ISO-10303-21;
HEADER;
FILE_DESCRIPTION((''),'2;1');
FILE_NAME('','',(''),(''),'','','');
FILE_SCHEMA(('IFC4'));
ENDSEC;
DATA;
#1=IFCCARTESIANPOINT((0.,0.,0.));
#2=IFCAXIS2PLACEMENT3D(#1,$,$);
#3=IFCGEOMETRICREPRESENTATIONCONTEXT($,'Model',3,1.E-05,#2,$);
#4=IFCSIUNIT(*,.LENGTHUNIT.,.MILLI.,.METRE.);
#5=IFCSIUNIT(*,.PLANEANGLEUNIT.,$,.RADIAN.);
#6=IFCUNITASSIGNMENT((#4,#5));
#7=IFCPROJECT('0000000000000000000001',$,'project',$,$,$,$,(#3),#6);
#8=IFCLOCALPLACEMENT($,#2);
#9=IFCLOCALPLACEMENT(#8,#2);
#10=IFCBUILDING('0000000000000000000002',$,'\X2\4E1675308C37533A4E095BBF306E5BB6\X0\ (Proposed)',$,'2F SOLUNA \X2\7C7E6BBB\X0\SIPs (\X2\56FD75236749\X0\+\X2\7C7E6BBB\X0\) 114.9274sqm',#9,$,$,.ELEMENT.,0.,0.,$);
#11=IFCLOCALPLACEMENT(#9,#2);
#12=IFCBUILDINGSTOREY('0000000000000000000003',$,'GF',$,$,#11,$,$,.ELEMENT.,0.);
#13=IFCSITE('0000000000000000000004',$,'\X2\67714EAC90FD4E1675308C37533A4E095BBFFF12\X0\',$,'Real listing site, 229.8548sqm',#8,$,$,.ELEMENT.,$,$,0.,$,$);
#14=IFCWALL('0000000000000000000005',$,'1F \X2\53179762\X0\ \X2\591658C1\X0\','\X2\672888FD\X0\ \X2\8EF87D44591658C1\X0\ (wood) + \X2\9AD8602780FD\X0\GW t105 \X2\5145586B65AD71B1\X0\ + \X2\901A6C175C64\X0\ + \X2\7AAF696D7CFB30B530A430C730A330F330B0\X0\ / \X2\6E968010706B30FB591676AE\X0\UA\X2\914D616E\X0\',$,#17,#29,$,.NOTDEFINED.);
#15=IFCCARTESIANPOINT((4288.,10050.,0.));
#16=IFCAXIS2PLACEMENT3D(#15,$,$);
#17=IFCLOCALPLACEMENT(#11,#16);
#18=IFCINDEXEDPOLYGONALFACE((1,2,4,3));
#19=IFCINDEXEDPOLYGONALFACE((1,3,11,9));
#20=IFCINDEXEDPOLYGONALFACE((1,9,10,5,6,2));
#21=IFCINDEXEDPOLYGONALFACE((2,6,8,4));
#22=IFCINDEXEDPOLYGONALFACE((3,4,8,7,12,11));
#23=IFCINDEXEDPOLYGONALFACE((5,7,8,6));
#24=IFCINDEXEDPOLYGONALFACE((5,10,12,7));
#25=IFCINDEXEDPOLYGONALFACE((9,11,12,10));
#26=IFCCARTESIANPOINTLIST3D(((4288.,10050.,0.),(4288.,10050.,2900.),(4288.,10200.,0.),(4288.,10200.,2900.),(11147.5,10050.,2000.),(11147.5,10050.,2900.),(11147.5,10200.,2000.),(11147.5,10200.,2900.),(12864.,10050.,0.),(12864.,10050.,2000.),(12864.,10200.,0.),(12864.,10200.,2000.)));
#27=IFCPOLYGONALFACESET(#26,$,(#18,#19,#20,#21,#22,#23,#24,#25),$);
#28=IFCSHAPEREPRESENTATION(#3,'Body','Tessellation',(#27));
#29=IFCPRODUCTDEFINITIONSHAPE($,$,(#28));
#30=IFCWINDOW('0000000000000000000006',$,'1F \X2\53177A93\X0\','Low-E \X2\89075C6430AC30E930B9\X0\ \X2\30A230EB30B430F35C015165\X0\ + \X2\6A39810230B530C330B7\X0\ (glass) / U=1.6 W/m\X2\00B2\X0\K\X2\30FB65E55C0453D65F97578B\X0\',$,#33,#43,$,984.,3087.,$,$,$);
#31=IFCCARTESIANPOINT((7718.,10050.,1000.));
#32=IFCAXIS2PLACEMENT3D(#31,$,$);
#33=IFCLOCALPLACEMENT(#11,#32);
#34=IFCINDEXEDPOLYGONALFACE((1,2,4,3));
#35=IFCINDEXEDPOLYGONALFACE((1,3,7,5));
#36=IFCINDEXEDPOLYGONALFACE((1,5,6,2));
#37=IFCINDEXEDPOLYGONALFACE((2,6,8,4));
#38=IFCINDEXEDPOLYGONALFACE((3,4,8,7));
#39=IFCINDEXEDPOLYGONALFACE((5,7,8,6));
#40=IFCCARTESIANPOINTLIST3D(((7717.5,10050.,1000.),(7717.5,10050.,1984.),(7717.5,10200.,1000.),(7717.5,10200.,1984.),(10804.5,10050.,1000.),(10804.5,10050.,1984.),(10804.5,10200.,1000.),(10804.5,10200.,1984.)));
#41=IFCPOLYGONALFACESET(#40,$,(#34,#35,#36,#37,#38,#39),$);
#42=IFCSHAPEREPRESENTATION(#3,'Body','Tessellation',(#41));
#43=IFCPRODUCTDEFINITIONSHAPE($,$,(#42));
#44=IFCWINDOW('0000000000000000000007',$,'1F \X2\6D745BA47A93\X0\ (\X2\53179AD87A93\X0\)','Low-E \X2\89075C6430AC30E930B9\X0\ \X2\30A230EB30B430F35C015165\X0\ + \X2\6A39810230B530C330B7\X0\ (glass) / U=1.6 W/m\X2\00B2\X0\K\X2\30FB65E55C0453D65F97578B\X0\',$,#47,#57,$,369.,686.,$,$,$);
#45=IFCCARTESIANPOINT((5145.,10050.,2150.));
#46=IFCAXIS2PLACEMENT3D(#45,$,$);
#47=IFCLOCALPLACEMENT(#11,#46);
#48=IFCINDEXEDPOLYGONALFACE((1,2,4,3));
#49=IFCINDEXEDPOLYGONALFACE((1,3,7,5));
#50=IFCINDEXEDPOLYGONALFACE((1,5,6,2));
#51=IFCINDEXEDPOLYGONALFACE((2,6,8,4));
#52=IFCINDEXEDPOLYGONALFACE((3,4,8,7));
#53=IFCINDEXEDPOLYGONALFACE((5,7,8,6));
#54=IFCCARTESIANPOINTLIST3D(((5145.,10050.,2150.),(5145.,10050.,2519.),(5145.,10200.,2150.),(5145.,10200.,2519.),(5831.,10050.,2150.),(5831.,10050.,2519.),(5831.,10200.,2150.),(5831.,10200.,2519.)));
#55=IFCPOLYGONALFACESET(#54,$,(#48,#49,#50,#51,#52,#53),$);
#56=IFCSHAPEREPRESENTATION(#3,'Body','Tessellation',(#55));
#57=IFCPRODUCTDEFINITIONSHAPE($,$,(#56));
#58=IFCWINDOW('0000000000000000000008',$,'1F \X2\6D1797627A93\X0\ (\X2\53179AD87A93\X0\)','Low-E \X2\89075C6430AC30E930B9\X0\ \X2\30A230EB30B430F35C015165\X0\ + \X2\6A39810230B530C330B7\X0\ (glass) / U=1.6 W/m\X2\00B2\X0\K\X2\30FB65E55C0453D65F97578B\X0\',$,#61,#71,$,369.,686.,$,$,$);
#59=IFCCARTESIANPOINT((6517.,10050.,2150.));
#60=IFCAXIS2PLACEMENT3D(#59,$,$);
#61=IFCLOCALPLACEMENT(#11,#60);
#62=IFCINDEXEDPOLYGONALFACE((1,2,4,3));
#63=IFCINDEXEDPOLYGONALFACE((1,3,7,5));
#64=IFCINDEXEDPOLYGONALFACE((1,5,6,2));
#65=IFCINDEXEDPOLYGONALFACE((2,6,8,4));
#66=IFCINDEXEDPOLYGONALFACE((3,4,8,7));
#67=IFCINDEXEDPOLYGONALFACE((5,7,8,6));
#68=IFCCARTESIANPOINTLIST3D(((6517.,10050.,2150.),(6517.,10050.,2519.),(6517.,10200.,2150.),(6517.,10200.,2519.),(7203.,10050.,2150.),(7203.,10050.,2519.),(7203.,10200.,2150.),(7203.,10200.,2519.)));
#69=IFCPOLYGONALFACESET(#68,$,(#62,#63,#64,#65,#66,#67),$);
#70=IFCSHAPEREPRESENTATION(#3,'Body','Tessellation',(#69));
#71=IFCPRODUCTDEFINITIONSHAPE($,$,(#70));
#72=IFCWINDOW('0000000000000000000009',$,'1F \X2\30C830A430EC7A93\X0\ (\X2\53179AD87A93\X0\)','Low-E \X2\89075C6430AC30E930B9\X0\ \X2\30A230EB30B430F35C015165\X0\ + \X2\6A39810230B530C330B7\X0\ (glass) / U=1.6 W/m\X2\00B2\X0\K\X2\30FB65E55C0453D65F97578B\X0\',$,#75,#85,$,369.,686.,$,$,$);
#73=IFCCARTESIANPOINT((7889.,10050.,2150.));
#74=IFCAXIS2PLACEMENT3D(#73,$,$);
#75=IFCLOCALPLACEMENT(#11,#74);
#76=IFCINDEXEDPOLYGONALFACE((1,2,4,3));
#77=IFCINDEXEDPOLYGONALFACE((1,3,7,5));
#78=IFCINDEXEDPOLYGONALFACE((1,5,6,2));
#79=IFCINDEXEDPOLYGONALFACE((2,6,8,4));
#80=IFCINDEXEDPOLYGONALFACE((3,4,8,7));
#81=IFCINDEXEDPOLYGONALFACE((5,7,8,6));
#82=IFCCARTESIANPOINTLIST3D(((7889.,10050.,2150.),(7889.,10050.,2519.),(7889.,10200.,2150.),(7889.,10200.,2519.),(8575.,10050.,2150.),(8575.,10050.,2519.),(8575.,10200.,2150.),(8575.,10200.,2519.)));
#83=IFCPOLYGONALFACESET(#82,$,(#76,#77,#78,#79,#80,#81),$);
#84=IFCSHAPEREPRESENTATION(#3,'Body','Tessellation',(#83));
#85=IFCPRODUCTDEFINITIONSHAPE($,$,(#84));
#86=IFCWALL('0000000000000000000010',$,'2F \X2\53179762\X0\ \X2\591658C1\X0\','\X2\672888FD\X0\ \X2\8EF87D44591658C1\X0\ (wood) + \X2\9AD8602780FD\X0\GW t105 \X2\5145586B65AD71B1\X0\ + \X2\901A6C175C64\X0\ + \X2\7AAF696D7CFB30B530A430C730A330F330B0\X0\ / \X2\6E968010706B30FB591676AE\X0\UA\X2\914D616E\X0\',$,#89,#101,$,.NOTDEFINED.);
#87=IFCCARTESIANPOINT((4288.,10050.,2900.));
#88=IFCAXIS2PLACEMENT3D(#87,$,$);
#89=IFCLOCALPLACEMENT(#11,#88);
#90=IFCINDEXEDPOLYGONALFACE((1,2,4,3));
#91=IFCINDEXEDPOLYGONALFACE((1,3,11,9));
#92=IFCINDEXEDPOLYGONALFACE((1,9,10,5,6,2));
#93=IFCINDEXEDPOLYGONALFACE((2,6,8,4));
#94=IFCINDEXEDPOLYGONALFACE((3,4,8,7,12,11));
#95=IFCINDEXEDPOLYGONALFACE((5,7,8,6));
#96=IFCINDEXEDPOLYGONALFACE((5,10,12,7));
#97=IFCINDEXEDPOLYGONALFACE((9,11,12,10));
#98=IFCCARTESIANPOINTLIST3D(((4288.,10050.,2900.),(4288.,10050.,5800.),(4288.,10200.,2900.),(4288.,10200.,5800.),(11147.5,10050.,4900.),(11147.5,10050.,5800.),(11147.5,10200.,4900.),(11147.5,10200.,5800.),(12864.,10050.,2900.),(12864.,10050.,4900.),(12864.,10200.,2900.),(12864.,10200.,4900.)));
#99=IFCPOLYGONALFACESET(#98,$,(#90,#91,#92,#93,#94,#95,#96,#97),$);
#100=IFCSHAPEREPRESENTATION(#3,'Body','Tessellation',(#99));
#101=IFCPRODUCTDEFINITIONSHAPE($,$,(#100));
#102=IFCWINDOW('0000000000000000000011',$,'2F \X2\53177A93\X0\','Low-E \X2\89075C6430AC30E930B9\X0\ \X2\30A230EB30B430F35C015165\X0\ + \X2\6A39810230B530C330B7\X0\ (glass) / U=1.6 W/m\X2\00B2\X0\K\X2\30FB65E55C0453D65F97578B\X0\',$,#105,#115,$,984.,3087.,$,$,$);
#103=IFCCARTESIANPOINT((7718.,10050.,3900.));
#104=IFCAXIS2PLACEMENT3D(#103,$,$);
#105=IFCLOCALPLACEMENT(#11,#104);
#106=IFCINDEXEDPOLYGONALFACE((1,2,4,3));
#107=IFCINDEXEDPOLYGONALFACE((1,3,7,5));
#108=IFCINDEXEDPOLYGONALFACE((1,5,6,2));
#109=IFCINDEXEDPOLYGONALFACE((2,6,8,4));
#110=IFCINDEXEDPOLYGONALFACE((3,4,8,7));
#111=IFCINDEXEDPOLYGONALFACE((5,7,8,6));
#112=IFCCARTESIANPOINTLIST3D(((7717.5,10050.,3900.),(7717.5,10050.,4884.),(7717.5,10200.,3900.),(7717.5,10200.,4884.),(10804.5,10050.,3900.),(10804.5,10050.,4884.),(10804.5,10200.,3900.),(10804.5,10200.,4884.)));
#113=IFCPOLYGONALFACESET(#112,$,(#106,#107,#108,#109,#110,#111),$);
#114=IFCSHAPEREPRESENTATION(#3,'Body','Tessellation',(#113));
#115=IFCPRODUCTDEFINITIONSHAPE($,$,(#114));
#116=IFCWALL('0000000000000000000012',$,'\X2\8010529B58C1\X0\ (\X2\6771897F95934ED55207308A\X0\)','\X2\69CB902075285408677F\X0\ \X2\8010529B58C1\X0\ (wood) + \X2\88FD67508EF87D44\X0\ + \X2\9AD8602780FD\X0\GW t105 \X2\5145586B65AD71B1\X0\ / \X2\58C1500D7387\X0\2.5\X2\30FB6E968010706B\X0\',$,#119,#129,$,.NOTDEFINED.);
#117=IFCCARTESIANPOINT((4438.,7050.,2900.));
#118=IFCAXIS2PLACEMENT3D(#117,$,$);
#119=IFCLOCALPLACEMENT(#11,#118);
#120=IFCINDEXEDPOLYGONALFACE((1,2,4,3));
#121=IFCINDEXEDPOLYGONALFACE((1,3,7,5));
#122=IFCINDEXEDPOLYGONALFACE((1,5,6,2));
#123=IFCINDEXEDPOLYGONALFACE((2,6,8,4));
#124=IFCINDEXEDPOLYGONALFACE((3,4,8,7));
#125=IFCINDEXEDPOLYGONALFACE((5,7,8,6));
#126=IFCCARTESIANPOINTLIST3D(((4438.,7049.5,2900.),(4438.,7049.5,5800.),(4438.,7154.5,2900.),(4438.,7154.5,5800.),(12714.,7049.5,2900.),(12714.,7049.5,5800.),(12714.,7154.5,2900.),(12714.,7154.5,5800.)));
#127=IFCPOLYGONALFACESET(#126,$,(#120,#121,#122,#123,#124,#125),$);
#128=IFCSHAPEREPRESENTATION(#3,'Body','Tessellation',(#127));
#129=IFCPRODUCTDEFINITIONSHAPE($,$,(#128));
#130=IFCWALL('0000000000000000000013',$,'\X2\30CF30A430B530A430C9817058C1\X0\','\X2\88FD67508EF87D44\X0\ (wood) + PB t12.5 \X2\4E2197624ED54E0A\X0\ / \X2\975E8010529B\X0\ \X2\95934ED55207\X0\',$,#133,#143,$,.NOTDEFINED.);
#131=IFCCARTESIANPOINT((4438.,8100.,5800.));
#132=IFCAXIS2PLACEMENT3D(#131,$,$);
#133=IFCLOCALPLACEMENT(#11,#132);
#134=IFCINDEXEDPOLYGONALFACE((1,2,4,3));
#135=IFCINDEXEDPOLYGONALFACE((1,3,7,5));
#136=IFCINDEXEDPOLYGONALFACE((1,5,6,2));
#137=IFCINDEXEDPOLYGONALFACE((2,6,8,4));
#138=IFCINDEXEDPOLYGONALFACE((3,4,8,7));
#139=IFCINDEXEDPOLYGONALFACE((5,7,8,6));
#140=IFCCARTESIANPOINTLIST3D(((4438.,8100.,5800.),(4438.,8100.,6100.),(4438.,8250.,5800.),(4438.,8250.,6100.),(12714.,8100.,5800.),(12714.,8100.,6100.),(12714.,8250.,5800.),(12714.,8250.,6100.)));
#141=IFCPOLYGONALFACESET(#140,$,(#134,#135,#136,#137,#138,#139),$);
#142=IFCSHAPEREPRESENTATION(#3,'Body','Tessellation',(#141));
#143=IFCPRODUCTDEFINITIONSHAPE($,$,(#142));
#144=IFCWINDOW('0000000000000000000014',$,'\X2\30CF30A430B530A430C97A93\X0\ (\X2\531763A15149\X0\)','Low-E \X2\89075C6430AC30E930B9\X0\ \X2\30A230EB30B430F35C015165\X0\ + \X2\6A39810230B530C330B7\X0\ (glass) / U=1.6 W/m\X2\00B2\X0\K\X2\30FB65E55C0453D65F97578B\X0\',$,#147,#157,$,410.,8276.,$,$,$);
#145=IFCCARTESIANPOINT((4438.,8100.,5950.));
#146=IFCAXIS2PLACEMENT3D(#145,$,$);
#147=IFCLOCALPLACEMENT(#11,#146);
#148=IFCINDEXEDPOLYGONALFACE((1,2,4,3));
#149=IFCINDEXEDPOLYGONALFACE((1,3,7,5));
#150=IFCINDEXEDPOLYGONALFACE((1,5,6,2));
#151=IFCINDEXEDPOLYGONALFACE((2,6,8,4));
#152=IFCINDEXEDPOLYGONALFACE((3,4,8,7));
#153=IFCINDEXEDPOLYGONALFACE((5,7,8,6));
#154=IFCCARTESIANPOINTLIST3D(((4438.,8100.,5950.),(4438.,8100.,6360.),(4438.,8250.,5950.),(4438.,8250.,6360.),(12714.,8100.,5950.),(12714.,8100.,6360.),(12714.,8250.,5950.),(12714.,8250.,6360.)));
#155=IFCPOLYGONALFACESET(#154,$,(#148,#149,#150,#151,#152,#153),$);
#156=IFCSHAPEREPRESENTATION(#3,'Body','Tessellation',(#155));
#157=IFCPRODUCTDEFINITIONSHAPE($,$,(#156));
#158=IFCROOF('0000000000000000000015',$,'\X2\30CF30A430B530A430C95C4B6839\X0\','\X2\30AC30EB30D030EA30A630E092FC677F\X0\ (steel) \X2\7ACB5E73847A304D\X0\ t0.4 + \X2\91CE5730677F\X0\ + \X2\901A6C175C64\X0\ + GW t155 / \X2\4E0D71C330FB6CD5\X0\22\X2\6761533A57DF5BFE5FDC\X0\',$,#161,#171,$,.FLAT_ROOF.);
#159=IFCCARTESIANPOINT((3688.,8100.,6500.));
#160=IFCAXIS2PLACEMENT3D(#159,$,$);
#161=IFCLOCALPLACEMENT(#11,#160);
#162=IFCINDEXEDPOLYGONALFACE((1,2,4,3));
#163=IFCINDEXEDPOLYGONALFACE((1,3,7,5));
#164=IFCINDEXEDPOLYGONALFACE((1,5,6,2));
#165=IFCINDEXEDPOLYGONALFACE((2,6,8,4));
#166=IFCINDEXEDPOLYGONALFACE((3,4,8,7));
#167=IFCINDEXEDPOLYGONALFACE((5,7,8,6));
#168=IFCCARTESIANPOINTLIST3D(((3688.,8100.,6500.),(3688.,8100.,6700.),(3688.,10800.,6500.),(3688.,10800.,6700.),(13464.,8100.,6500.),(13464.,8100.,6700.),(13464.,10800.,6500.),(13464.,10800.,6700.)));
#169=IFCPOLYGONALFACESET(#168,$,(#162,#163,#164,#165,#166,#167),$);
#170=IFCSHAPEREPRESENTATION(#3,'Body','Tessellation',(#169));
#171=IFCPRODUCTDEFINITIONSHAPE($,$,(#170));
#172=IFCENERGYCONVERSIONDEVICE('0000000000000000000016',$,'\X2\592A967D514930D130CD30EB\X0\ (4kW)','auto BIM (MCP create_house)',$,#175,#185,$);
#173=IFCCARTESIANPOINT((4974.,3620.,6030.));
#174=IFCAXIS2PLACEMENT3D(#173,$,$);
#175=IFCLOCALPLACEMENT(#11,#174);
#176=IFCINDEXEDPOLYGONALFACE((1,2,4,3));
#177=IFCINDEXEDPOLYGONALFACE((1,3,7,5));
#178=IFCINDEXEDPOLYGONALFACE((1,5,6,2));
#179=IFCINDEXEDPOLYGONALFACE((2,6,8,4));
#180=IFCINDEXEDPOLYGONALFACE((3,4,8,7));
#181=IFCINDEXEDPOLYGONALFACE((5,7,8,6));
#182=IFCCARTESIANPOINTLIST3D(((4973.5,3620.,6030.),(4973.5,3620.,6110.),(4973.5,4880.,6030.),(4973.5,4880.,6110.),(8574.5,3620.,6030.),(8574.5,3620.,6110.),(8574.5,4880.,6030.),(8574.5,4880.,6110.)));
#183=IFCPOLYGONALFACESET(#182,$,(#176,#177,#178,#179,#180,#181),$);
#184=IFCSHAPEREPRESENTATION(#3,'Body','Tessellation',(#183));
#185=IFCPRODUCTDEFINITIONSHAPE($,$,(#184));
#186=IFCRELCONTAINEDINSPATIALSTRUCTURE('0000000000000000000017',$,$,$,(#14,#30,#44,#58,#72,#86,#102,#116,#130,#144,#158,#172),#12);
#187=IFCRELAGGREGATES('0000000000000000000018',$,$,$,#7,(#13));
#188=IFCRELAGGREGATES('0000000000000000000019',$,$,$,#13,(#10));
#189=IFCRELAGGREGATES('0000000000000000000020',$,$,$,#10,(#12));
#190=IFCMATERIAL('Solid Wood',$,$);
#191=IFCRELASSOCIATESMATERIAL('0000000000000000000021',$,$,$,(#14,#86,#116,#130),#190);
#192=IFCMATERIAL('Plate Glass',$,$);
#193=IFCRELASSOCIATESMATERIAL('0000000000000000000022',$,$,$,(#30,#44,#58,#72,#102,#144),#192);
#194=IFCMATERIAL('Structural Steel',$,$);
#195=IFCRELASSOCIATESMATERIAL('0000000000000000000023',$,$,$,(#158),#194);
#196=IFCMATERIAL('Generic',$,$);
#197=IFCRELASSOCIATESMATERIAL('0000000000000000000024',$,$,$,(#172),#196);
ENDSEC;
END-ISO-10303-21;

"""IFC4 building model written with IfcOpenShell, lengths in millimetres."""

from ifc_helpers import new_model, si_unit, frame, frame_2d, origin, place, context, project, spatial, rectangle, extrude, material, element, fill, save


model = new_model("IFC4")

# Units and contexts
model_context = context("Model", 3, precision=1e-05, world=origin())
ifc_project = project(units=[si_unit("LENGTHUNIT", "METRE", prefix="MILLI"), si_unit("PLANEANGLEUNIT", "RADIAN")], contexts=[model_context])

# Site, building, storey
site_placement = place(None, origin())
site = spatial("IfcSite", under=ifc_project, at=site_placement, Name="東京都世田谷区三宿２", ObjectType="Real listing site, 229.8548sqm", CompositionType="ELEMENT", RefElevation=0.0)
building_placement = place(site_placement, origin())
building = spatial("IfcBuilding", under=site, at=building_placement, Name="世田谷区三宿の家 (Proposed)", ObjectType="2F SOLUNA 籾殻SIPs (国産杉+籾殻) 114.9274sqm", CompositionType="ELEMENT", ElevationOfRefHeight=0.0, ElevationOfTerrain=0.0)
storey_placement = place(building_placement, origin())
storey = spatial("IfcBuildingStorey", under=building, at=storey_placement, Name="GF", CompositionType="ELEMENT", Elevation=0.0)

# Wall, openings, windows
ifc_material_1 = material(Name="Solid Wood")
wall_1_placement = place(storey_placement, frame((4288.0, 10050.0, 0.0)))
wall_1 = element("IfcWall", 1, at=wall_1_placement, inside=storey, material=ifc_material_1, Name="1F 北面 外壁", Description="木製 軸組外壁 (wood) + 高性能GW t105 充填断熱 + 通気層 + 窯業系サイディング / 準耐火・外皮UA配慮", PredefinedType="NOTDEFINED", context=model_context, shape_type="SweptSolid", body=[
    extrude(rectangle(XDim=8576.0, YDim=150.0, at=frame_2d((4288.0, 75.0))), frame((4288.0, 10050.0, 0.0)), (0.0, 0.0, 1.0), 2900.0),
])
opening_1_placement = place(storey_placement, frame((7718.0, 10050.0, 1000.0)))
opening_1 = element("IfcOpeningElement", 2, at=opening_1_placement, cuts=wall_1, PredefinedType="NOTDEFINED", context=model_context, shape_type="SweptSolid", body=[
    extrude(rectangle(XDim=3087.0, YDim=150.0, at=frame_2d((1543.0, 75.0))), frame((7718.0, 10050.0, 1000.0)), (0.0, 0.0, 1.0), 984.0),
])
opening_2_placement = place(storey_placement, frame((5145.0, 10050.0, 2150.0)))
opening_2 = element("IfcOpeningElement", 3, at=opening_2_placement, cuts=wall_1, PredefinedType="NOTDEFINED", context=model_context, shape_type="SweptSolid", body=[
    extrude(rectangle(XDim=686.0, YDim=150.0, at=frame_2d((343.0, 75.0))), frame((5145.0, 10050.0, 2150.0)), (0.0, 0.0, 1.0), 369.0),
])
opening_3_placement = place(storey_placement, frame((6517.0, 10050.0, 2150.0)))
opening_3 = element("IfcOpeningElement", 4, at=opening_3_placement, cuts=wall_1, PredefinedType="NOTDEFINED", context=model_context, shape_type="SweptSolid", body=[
    extrude(rectangle(XDim=686.0, YDim=150.0, at=frame_2d((343.0, 75.0))), frame((6517.0, 10050.0, 2150.0)), (0.0, 0.0, 1.0), 369.0),
])
opening_4_placement = place(storey_placement, frame((7889.0, 10050.0, 2150.0)))
opening_4 = element("IfcOpeningElement", 5, at=opening_4_placement, cuts=wall_1, PredefinedType="NOTDEFINED", context=model_context, shape_type="SweptSolid", body=[
    extrude(rectangle(XDim=686.0, YDim=150.0, at=frame_2d((343.0, 75.0))), frame((7889.0, 10050.0, 2150.0)), (0.0, 0.0, 1.0), 369.0),
])
ifc_material_2 = material(Name="Plate Glass")
window_1_placement = place(storey_placement, frame((7718.0, 10050.0, 1000.0)))
window_1 = element("IfcWindow", 6, at=window_1_placement, inside=storey, material=ifc_material_2, Name="1F 北窓", Description="Low-E 複層ガラス アルゴン封入 + 樹脂サッシ (glass) / U=1.6 W/m²K・日射取得型", OverallHeight=984.0, OverallWidth=3087.0, context=model_context, shape_type="SweptSolid", body=[
    extrude(rectangle(XDim=3087.0, YDim=150.0, at=frame_2d((1543.0, 75.0))), frame((7718.0, 10050.0, 1000.0)), (0.0, 0.0, 1.0), 984.0),
])
fill(opening_1, window_1)
window_2_placement = place(storey_placement, frame((5145.0, 10050.0, 2150.0)))
window_2 = element("IfcWindow", 7, at=window_2_placement, inside=storey, material=ifc_material_2, Name="1F 浴室窓 (北高窓)", Description="Low-E 複層ガラス アルゴン封入 + 樹脂サッシ (glass) / U=1.6 W/m²K・日射取得型", OverallHeight=369.0, OverallWidth=686.0, context=model_context, shape_type="SweptSolid", body=[
    extrude(rectangle(XDim=686.0, YDim=150.0, at=frame_2d((343.0, 75.0))), frame((5145.0, 10050.0, 2150.0)), (0.0, 0.0, 1.0), 369.0),
])
fill(opening_2, window_2)
window_3_placement = place(storey_placement, frame((6517.0, 10050.0, 2150.0)))
window_3 = element("IfcWindow", 8, at=window_3_placement, inside=storey, material=ifc_material_2, Name="1F 洗面窓 (北高窓)", Description="Low-E 複層ガラス アルゴン封入 + 樹脂サッシ (glass) / U=1.6 W/m²K・日射取得型", OverallHeight=369.0, OverallWidth=686.0, context=model_context, shape_type="SweptSolid", body=[
    extrude(rectangle(XDim=686.0, YDim=150.0, at=frame_2d((343.0, 75.0))), frame((6517.0, 10050.0, 2150.0)), (0.0, 0.0, 1.0), 369.0),
])
fill(opening_3, window_3)
window_4_placement = place(storey_placement, frame((7889.0, 10050.0, 2150.0)))
window_4 = element("IfcWindow", 9, at=window_4_placement, inside=storey, material=ifc_material_2, Name="1F トイレ窓 (北高窓)", Description="Low-E 複層ガラス アルゴン封入 + 樹脂サッシ (glass) / U=1.6 W/m²K・日射取得型", OverallHeight=369.0, OverallWidth=686.0, context=model_context, shape_type="SweptSolid", body=[
    extrude(rectangle(XDim=686.0, YDim=150.0, at=frame_2d((343.0, 75.0))), frame((7889.0, 10050.0, 2150.0)), (0.0, 0.0, 1.0), 369.0),
])
fill(opening_4, window_4)

# Wall, opening, window
wall_2_placement = place(storey_placement, frame((4288.0, 10050.0, 2900.0)))
wall_2 = element("IfcWall", 10, at=wall_2_placement, inside=storey, material=ifc_material_1, Name="2F 北面 外壁", Description="木製 軸組外壁 (wood) + 高性能GW t105 充填断熱 + 通気層 + 窯業系サイディング / 準耐火・外皮UA配慮", PredefinedType="NOTDEFINED", context=model_context, shape_type="SweptSolid", body=[
    extrude(rectangle(XDim=8576.0, YDim=150.0, at=frame_2d((4288.0, 75.0))), frame((4288.0, 10050.0, 2900.0)), (0.0, 0.0, 1.0), 2900.0),
])
opening_5_placement = place(storey_placement, frame((7718.0, 10050.0, 3900.0)))
opening_5 = element("IfcOpeningElement", 11, at=opening_5_placement, cuts=wall_2, PredefinedType="NOTDEFINED", context=model_context, shape_type="SweptSolid", body=[
    extrude(rectangle(XDim=3087.0, YDim=150.0, at=frame_2d((1543.0, 75.0))), frame((7718.0, 10050.0, 3900.0)), (0.0, 0.0, 1.0), 984.0),
])
window_5_placement = place(storey_placement, frame((7718.0, 10050.0, 3900.0)))
window_5 = element("IfcWindow", 12, at=window_5_placement, inside=storey, material=ifc_material_2, Name="2F 北窓", Description="Low-E 複層ガラス アルゴン封入 + 樹脂サッシ (glass) / U=1.6 W/m²K・日射取得型", OverallHeight=984.0, OverallWidth=3087.0, context=model_context, shape_type="SweptSolid", body=[
    extrude(rectangle(XDim=3087.0, YDim=150.0, at=frame_2d((1543.0, 75.0))), frame((7718.0, 10050.0, 3900.0)), (0.0, 0.0, 1.0), 984.0),
])
fill(opening_5, window_5)

# Wall
wall_3_placement = place(storey_placement, frame((4438.0, 7050.0, 2900.0)))
element("IfcWall", 13, at=wall_3_placement, inside=storey, material=ifc_material_1, Name="耐力壁 (東西間仕切り)", Description="構造用合板 耐力壁 (wood) + 製材軸組 + 高性能GW t105 充填断熱 / 壁倍率2.5・準耐火", PredefinedType="NOTDEFINED", context=model_context, shape_type="SweptSolid", body=[
    extrude(rectangle(XDim=8276.0, YDim=105.0, at=frame_2d((4138.0, 52.0))), frame((4438.0, 7050.0, 2900.0)), (0.0, 0.0, 1.0), 2900.0),
])

# Wall, opening, window
wall_4_placement = place(storey_placement, frame((4438.0, 8100.0, 5800.0)))
wall_4 = element("IfcWall", 14, at=wall_4_placement, inside=storey, material=ifc_material_1, Name="ハイサイド腰壁", Description="製材軸組 (wood) + PB t12.5 両面仕上 / 非耐力 間仕切", PredefinedType="NOTDEFINED", context=model_context, shape_type="SweptSolid", body=[
    extrude(rectangle(XDim=8276.0, YDim=150.0, at=frame_2d((4138.0, 75.0))), frame((4438.0, 8100.0, 5800.0)), (0.0, 0.0, 1.0), 700.0),
])
opening_6_placement = place(storey_placement, frame((4438.0, 8100.0, 5950.0)))
opening_6 = element("IfcOpeningElement", 15, at=opening_6_placement, cuts=wall_4, PredefinedType="NOTDEFINED", context=model_context, shape_type="SweptSolid", body=[
    extrude(rectangle(XDim=8276.0, YDim=150.0, at=frame_2d((4138.0, 75.0))), frame((4438.0, 8100.0, 5950.0)), (0.0, 0.0, 1.0), 410.0),
])
window_6_placement = place(storey_placement, frame((4438.0, 8100.0, 5950.0)))
window_6 = element("IfcWindow", 16, at=window_6_placement, inside=storey, material=ifc_material_2, Name="ハイサイド窓 (北採光)", Description="Low-E 複層ガラス アルゴン封入 + 樹脂サッシ (glass) / U=1.6 W/m²K・日射取得型", OverallHeight=410.0, OverallWidth=8276.0, context=model_context, shape_type="SweptSolid", body=[
    extrude(rectangle(XDim=8276.0, YDim=150.0, at=frame_2d((4138.0, 75.0))), frame((4438.0, 8100.0, 5950.0)), (0.0, 0.0, 1.0), 410.0),
])
fill(opening_6, window_6)

# Roof
ifc_material_3 = material(Name="Structural Steel")
roof_placement = place(storey_placement, frame((3688.0, 8100.0, 6500.0)))
element("IfcRoof", 17, at=roof_placement, inside=storey, material=ifc_material_3, Name="ハイサイド屋根", Description="ガルバリウム鋼板 (steel) 立平葺き t0.4 + 野地板 + 通気層 + GW t155 / 不燃・法22条区域対応", PredefinedType="FLAT_ROOF", context=model_context, shape_type="SweptSolid", body=[
    extrude(rectangle(XDim=9776.0, YDim=2700.0, at=frame_2d((4888.0, 1350.0))), frame((3688.0, 8100.0, 6500.0)), (0.0, 0.0, 1.0), 200.0),
])

# Energy conversion device
ifc_material_4 = material(Name="Generic")
energy_conversion_device_placement = place(storey_placement, frame((4974.0, 3620.0, 6030.0)))
element("IfcEnergyConversionDevice", 18, at=energy_conversion_device_placement, inside=storey, material=ifc_material_4, Name="太陽光パネル (4kW)", Description="auto BIM (MCP create_house)", context=model_context, shape_type="SweptSolid", body=[
    extrude(rectangle(XDim=3601.0, YDim=1260.0, at=frame_2d((1800.0, 630.0))), frame((4974.0, 3620.0, 6030.0)), (0.0, 0.0, 1.0), 80.0),
])

save(model, "model.ifc")
